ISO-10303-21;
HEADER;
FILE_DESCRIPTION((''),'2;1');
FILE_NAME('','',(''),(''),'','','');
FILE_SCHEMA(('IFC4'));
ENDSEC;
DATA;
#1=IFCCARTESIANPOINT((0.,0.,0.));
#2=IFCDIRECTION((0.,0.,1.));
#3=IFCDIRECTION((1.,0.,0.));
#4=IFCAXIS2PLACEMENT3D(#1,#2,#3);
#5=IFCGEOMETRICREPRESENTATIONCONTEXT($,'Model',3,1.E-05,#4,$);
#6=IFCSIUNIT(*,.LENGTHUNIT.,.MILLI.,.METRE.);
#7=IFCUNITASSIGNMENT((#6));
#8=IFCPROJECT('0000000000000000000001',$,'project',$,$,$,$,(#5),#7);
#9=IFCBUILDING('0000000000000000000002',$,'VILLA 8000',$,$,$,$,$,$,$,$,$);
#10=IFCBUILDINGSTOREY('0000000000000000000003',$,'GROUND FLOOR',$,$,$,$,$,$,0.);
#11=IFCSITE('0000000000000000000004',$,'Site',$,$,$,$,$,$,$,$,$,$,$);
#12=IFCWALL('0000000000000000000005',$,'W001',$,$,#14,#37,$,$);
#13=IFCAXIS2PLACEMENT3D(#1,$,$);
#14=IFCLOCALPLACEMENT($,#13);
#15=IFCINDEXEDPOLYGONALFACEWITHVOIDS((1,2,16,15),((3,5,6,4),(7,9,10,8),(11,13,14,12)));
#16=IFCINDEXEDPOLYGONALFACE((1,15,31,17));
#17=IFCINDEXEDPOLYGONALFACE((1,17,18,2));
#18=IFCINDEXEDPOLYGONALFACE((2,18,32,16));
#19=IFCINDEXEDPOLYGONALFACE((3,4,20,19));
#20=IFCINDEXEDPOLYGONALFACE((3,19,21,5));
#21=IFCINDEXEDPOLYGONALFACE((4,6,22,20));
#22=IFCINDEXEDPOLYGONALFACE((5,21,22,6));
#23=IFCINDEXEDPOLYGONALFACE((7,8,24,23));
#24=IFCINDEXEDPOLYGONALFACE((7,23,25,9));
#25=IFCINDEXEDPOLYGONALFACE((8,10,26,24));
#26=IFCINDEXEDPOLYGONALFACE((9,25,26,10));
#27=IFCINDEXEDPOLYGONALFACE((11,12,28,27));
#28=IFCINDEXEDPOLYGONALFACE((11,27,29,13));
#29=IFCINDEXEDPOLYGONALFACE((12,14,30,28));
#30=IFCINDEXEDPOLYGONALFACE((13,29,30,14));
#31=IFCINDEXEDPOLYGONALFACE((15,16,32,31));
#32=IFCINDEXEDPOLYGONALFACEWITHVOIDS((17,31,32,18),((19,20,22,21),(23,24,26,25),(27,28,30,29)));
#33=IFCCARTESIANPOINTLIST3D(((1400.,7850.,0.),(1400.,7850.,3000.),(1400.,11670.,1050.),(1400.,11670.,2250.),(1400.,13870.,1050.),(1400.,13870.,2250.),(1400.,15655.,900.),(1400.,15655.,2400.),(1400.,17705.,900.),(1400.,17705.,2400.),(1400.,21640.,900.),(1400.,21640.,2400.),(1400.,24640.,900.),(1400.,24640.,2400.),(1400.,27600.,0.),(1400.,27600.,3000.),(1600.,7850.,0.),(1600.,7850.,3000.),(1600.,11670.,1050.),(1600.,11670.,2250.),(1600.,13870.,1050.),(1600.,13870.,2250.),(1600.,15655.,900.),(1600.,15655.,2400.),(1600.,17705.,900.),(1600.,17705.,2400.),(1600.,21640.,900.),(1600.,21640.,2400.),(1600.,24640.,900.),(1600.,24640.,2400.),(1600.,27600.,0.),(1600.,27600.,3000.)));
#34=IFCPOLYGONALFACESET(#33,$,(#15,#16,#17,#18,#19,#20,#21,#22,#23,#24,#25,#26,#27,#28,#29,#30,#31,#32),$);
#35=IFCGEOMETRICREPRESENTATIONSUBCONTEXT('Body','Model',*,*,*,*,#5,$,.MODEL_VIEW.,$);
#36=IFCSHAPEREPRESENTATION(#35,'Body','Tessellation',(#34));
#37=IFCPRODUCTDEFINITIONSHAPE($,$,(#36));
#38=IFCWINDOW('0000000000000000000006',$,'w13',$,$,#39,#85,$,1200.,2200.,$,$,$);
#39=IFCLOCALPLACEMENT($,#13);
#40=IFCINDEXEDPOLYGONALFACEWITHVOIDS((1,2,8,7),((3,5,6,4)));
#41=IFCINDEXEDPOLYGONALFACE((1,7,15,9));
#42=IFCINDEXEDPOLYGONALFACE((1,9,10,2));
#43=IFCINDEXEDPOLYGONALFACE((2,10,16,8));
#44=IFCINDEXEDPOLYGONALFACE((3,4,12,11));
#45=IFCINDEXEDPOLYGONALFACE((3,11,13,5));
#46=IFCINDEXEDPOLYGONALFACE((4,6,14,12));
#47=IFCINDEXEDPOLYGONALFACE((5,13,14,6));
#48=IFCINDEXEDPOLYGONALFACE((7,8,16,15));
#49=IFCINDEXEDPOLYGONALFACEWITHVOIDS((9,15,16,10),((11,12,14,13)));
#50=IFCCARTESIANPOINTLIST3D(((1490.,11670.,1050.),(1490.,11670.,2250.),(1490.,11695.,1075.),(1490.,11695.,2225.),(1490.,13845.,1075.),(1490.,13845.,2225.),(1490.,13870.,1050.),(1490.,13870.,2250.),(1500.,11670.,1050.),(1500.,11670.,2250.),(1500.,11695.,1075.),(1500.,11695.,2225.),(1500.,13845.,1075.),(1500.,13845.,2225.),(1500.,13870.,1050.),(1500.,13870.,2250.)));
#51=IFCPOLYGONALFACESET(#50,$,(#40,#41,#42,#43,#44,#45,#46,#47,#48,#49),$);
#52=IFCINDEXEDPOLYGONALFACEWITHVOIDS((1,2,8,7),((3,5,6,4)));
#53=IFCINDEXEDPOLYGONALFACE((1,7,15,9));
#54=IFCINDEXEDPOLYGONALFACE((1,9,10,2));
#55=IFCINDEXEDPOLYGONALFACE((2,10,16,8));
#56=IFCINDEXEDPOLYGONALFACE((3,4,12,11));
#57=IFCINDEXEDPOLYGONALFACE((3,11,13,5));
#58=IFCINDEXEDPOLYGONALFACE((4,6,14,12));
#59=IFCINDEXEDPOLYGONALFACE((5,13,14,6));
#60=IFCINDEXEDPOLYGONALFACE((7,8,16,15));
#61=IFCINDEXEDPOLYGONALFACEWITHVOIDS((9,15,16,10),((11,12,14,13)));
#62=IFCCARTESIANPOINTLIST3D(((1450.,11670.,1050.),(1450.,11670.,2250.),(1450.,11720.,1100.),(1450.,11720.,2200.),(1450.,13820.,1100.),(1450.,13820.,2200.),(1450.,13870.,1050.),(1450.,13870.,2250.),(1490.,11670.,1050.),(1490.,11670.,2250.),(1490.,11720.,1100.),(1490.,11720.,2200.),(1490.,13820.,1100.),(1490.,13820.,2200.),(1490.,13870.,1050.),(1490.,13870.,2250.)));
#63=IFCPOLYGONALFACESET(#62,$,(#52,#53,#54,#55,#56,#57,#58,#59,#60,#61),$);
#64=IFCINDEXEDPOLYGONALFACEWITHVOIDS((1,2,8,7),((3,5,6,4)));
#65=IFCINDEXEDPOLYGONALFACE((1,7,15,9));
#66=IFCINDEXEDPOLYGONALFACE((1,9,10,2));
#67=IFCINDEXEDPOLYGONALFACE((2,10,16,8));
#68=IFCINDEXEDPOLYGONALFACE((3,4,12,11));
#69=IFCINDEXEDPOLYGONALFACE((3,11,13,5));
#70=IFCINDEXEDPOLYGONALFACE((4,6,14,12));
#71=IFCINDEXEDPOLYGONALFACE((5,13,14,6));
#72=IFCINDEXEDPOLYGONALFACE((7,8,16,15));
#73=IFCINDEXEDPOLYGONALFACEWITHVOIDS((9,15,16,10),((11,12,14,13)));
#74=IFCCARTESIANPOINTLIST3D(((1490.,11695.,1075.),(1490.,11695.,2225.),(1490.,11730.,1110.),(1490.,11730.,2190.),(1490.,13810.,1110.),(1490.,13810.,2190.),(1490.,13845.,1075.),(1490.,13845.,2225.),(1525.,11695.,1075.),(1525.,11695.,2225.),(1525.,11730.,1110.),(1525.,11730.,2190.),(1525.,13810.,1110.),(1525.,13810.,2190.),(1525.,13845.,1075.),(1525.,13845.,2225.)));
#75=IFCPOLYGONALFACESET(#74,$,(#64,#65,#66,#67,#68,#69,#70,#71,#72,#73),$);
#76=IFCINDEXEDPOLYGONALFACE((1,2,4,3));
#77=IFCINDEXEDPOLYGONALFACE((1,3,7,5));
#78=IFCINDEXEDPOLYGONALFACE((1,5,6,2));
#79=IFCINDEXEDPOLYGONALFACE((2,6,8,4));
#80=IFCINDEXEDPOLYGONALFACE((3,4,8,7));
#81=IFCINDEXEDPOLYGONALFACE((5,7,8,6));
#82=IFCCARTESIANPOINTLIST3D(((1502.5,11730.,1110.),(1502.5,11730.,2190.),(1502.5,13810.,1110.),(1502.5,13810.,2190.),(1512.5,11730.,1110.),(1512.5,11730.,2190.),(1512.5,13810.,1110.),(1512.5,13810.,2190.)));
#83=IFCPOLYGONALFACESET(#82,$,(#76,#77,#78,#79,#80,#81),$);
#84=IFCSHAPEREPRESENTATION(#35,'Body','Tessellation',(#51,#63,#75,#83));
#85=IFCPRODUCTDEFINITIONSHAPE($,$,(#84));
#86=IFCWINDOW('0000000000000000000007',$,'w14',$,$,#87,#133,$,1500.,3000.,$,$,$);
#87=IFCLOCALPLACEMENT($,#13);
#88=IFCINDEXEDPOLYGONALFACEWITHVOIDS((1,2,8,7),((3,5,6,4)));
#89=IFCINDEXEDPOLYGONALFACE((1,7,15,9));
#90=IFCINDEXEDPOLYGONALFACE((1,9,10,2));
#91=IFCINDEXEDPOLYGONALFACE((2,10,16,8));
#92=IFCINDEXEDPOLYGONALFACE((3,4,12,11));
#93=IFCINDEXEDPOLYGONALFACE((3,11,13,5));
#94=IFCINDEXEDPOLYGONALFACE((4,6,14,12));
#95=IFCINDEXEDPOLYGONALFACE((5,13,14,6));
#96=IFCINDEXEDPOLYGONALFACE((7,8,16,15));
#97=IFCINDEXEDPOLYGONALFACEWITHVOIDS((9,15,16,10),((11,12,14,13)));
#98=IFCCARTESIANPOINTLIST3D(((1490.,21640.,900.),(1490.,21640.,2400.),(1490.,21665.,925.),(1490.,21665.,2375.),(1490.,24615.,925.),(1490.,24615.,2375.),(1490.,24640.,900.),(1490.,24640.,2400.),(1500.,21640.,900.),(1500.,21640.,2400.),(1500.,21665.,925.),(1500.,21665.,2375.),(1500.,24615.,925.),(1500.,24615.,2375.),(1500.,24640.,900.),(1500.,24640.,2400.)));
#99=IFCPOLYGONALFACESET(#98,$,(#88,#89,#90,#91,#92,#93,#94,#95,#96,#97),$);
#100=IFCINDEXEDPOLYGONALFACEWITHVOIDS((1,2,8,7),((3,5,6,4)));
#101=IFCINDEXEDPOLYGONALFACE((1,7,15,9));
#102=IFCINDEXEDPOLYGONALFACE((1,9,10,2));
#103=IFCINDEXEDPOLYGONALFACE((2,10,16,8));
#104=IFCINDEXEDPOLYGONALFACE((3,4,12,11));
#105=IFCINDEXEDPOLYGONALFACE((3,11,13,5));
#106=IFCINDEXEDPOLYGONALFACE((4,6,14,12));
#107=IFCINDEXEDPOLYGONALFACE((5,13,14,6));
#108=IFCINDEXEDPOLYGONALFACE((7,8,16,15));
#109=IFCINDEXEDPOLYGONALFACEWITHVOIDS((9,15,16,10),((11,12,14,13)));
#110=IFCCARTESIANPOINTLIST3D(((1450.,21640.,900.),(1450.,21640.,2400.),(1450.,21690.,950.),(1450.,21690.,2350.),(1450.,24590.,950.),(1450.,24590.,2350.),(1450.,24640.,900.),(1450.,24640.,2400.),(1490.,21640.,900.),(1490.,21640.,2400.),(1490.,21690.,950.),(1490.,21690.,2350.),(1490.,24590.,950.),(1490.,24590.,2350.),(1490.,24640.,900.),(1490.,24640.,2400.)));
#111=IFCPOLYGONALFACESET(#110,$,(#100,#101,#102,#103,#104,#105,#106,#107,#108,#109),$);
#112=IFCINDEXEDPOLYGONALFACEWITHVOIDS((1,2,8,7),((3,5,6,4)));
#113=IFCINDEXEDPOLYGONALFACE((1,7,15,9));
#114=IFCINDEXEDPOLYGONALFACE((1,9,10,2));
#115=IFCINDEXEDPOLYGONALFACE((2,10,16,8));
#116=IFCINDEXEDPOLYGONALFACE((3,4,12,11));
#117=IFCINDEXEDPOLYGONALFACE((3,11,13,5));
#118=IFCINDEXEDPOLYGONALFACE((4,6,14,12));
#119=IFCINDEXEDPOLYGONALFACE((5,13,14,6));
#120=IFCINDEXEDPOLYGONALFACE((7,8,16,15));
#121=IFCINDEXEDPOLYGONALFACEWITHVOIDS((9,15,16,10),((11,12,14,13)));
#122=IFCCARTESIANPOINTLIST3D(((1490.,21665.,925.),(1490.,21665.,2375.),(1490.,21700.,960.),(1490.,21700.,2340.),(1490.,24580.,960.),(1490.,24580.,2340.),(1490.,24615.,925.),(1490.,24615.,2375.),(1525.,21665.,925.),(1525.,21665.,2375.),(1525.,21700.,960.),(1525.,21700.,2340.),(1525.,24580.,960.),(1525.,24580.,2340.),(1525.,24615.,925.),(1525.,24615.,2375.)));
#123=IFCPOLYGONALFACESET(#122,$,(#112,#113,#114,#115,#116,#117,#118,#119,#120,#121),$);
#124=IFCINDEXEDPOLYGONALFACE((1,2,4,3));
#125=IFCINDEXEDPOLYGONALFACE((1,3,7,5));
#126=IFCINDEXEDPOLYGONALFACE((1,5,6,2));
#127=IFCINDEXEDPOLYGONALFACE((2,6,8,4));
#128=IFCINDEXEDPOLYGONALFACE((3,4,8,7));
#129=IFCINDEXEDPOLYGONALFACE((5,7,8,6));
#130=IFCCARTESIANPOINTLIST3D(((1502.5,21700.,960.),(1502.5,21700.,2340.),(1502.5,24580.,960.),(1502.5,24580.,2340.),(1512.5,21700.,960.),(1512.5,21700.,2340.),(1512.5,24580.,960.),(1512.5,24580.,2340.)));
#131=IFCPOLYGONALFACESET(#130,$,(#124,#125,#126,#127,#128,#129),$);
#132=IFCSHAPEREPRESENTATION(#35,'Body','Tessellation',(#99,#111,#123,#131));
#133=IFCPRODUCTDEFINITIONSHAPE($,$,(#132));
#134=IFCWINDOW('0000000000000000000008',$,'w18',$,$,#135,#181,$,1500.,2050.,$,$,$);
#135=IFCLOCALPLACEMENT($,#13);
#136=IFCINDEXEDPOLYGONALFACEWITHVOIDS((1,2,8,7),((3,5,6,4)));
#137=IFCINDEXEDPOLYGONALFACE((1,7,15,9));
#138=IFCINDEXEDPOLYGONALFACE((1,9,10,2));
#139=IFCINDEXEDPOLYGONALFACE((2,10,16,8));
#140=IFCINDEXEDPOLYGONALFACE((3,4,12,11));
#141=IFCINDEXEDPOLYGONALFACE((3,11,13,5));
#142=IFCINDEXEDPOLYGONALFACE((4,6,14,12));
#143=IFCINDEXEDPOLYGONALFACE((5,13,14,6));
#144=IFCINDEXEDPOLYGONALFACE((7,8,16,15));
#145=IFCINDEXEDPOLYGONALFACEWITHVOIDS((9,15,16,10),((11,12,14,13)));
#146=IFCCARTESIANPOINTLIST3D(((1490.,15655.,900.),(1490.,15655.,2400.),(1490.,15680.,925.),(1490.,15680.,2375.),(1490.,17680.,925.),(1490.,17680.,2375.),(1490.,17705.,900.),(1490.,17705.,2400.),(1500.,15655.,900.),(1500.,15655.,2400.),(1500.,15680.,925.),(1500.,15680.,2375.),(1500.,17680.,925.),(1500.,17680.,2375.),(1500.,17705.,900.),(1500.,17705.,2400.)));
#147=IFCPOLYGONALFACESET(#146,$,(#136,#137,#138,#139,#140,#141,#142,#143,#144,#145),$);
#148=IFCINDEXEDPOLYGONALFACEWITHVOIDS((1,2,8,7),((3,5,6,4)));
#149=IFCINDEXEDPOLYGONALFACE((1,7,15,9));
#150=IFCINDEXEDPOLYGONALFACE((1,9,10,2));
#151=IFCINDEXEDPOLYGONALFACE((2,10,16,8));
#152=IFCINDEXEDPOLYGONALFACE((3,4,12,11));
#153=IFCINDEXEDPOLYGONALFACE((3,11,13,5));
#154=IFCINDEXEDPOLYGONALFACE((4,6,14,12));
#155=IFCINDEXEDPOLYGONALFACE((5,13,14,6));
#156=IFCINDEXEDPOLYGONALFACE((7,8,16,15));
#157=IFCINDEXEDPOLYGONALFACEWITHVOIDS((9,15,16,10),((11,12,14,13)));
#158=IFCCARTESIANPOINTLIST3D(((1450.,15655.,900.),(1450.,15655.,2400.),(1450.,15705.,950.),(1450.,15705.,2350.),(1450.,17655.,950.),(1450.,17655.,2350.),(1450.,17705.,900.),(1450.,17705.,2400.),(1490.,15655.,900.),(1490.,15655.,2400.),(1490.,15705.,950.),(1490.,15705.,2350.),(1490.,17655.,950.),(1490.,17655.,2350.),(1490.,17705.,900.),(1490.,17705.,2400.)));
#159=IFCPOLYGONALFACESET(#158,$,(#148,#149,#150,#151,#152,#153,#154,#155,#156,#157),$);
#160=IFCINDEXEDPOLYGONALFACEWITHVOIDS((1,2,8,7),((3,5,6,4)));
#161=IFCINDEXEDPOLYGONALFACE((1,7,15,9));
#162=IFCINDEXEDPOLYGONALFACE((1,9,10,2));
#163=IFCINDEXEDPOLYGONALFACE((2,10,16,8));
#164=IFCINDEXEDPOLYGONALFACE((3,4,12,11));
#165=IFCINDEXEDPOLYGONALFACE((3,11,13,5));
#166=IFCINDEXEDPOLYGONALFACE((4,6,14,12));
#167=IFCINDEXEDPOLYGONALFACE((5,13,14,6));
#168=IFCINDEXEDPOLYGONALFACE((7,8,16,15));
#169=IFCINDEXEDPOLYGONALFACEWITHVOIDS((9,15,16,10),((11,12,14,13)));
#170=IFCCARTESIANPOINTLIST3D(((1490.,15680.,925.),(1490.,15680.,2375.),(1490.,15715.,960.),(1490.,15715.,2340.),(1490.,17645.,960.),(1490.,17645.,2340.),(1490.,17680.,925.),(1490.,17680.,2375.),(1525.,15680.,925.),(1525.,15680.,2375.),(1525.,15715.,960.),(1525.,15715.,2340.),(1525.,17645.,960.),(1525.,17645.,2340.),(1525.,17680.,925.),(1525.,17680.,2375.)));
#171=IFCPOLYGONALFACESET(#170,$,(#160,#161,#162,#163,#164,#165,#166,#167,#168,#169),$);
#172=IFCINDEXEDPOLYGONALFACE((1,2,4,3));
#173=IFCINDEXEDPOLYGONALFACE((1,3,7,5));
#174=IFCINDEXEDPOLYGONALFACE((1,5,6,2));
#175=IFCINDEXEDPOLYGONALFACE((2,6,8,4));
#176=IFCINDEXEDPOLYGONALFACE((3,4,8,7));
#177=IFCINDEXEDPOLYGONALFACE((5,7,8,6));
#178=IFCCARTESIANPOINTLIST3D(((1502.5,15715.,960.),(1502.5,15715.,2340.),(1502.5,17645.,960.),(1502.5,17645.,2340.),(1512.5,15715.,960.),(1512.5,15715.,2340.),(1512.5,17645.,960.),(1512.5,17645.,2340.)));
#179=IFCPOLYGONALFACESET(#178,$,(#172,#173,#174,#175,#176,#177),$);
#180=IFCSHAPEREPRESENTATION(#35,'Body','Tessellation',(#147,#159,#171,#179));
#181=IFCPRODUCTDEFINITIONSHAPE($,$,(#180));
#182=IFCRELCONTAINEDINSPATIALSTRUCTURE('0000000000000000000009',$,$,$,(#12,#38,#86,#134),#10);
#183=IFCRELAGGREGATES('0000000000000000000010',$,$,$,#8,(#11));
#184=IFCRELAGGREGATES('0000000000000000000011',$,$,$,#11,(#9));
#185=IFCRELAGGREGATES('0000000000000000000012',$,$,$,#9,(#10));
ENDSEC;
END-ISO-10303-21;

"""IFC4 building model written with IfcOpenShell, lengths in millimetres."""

from ifc_helpers import new_model, si_unit, frame, origin_with_axes, place, context, subcontext, project, spatial, line, indexed_curve, outline, extrude, element, fill, save


model = new_model("IFC4")

# Units and contexts
model_context = context("Model", 3, precision=1e-05, world=origin_with_axes())
body_context = subcontext(model_context, "Body", "Model", "MODEL_VIEW")
ifc_project = project(units=[si_unit("LENGTHUNIT", "METRE", prefix="MILLI")], contexts=[model_context])

# Site, building, storey
site = spatial("IfcSite", under=ifc_project, Name="Site")
building = spatial("IfcBuilding", under=site, Name="VILLA 8000")
storey = spatial("IfcBuildingStorey", under=building, Name="GROUND FLOOR", Elevation=0.0)

# Wall, openings, windows
wall_1_placement = place(None, frame((1500.0, 27600.0, 0.0), z_axis=(0.0, 0.0, 1.0), x_axis=(0.0, -1.0, 0.0)))
wall_1 = element("IfcWall", 1, at=wall_1_placement, inside=storey, Name="W001", context=body_context, shape_type="SweptSolid", body=[
    extrude(outline(indexed_curve([(0.0, 0.0), (0.0, 200.0), (19750.0, 200.0), (19750.0, 0.0), (0.0, 0.0)], self_intersect=False)), frame((0.0, -100.0, 0.0), z_axis=(0.0, 0.0, 1.0), x_axis=(1.0, 0.0, 0.0)), (0.0, 0.0, 1.0), 3000.0),
])
opening_1_placement = place(wall_1_placement, frame((13730.0, 0.0, 1050.0), z_axis=(0.0, 0.0, 1.0), x_axis=(1.0, 0.0, 0.0)))
opening_1 = element("IfcOpeningElement", 2, at=opening_1_placement, cuts=wall_1, context=body_context, shape_type="SweptSolid", body=[
    extrude(outline(indexed_curve([(0.0, 0.0), (0.0, 300.0), (2200.0, 300.0), (2200.0, 0.0), (0.0, 0.0)], self_intersect=False)), frame((0.0, -150.0, 0.0), z_axis=(0.0, 0.0, 1.0), x_axis=(1.0, 0.0, 0.0)), (0.0, 0.0, 1.0), 1200.0),
])
opening_2_placement = place(wall_1_placement, frame((2960.0, 0.0, 900.0), z_axis=(0.0, 0.0, 1.0), x_axis=(1.0, 0.0, 0.0)))
opening_2 = element("IfcOpeningElement", 3, at=opening_2_placement, cuts=wall_1, context=body_context, shape_type="SweptSolid", body=[
    extrude(outline(indexed_curve([(0.0, 0.0), (0.0, 300.0), (3000.0, 300.0), (3000.0, 0.0), (0.0, 0.0)], self_intersect=False)), frame((0.0, -150.0, 0.0), z_axis=(0.0, 0.0, 1.0), x_axis=(1.0, 0.0, 0.0)), (0.0, 0.0, 1.0), 1500.0),
])
opening_3_placement = place(wall_1_placement, frame((9895.0, 0.0, 900.0), z_axis=(0.0, 0.0, 1.0), x_axis=(1.0, 0.0, 0.0)))
opening_3 = element("IfcOpeningElement", 4, at=opening_3_placement, cuts=wall_1, context=body_context, shape_type="SweptSolid", body=[
    extrude(outline(indexed_curve([(0.0, 0.0), (0.0, 300.0), (2050.0, 300.0), (2050.0, 0.0), (0.0, 0.0)], self_intersect=False)), frame((0.0, -150.0, 0.0), z_axis=(0.0, 0.0, 1.0), x_axis=(1.0, 0.0, 0.0)), (0.0, 0.0, 1.0), 1500.0),
])
window_1_placement = place(None, frame((1400.0, 13870.0, 1050.0), z_axis=(0.0, 0.0, 1.0), x_axis=(0.0, -1.0, 0.0)))
window_1 = element("IfcWindow", 5, at=window_1_placement, inside=storey, Name="w13", OverallHeight=1200.0, OverallWidth=2200.0, context=body_context, shape_type="SweptSolid", body=[
    extrude(outline(indexed_curve([(0.0, 0.0), (2200.0, 0.0), (2200.0, 1200.0), (0.0, 1200.0)], segments=[line(1, 2, 3, 4, 1)]), holes=[indexed_curve([(25.0, 25.0), (2175.0, 25.0), (2175.0, 1175.0), (25.0, 1175.0)], segments=[line(1, 2, 3, 4, 1)])]), frame((0.0, 90.0, 0.0), z_axis=(0.0, -1.0, 0.0), x_axis=(1.0, 0.0, 0.0)), (0.0, 0.0, -1.0), 10.0),
    extrude(outline(indexed_curve([(0.0, 0.0), (2200.0, 0.0), (2200.0, 1200.0), (0.0, 1200.0)], segments=[line(1, 2, 3, 4, 1)]), holes=[indexed_curve([(50.0, 50.0), (2150.0, 50.0), (2150.0, 1150.0), (50.0, 1150.0)], segments=[line(1, 2, 3, 4, 1)])]), frame((0.0, 50.0, 0.0), z_axis=(0.0, -1.0, 0.0), x_axis=(1.0, 0.0, 0.0)), (0.0, 0.0, -1.0), 40.0),
    extrude(outline(indexed_curve([(0.0, 0.0), (2150.0, 0.0), (2150.0, 1150.0), (0.0, 1150.0)], segments=[line(1, 2, 3, 4, 1)]), holes=[indexed_curve([(35.0, 35.0), (2115.0, 35.0), (2115.0, 1115.0), (35.0, 1115.0)], segments=[line(1, 2, 3, 4, 1)])]), frame((25.0, 90.0, 25.0), z_axis=(0.0, -1.0, 0.0), x_axis=(1.0, 0.0, 0.0)), (0.0, 0.0, -1.0), 35.0),
    extrude(outline(indexed_curve([(35.0, 35.0), (2115.0, 35.0), (2115.0, 1115.0), (35.0, 1115.0)], segments=[line(1, 2, 3, 4, 1)])), frame((25.0, 102.5, 25.0), z_axis=(0.0, -1.0, 0.0), x_axis=(1.0, 0.0, 0.0)), (0.0, 0.0, -1.0), 10.0),
])
fill(opening_1, window_1)
window_2_placement = place(None, frame((1400.0, 24640.0, 900.0), z_axis=(0.0, 0.0, 1.0), x_axis=(0.0, -1.0, 0.0)))
window_2 = element("IfcWindow", 6, at=window_2_placement, inside=storey, Name="w14", OverallHeight=1500.0, OverallWidth=3000.0, context=body_context, shape_type="SweptSolid", body=[
    extrude(outline(indexed_curve([(0.0, 0.0), (3000.0, 0.0), (3000.0, 1500.0), (0.0, 1500.0)], segments=[line(1, 2, 3, 4, 1)]), holes=[indexed_curve([(25.0, 25.0), (2975.0, 25.0), (2975.0, 1475.0), (25.0, 1475.0)], segments=[line(1, 2, 3, 4, 1)])]), frame((0.0, 90.0, 0.0), z_axis=(0.0, -1.0, 0.0), x_axis=(1.0, 0.0, 0.0)), (0.0, 0.0, -1.0), 10.0),
    extrude(outline(indexed_curve([(0.0, 0.0), (3000.0, 0.0), (3000.0, 1500.0), (0.0, 1500.0)], segments=[line(1, 2, 3, 4, 1)]), holes=[indexed_curve([(50.0, 50.0), (2950.0, 50.0), (2950.0, 1450.0), (50.0, 1450.0)], segments=[line(1, 2, 3, 4, 1)])]), frame((0.0, 50.0, 0.0), z_axis=(0.0, -1.0, 0.0), x_axis=(1.0, 0.0, 0.0)), (0.0, 0.0, -1.0), 40.0),
    extrude(outline(indexed_curve([(0.0, 0.0), (2950.0, 0.0), (2950.0, 1450.0), (0.0, 1450.0)], segments=[line(1, 2, 3, 4, 1)]), holes=[indexed_curve([(35.0, 35.0), (2915.0, 35.0), (2915.0, 1415.0), (35.0, 1415.0)], segments=[line(1, 2, 3, 4, 1)])]), frame((25.0, 90.0, 25.0), z_axis=(0.0, -1.0, 0.0), x_axis=(1.0, 0.0, 0.0)), (0.0, 0.0, -1.0), 35.0),
    extrude(outline(indexed_curve([(35.0, 35.0), (2915.0, 35.0), (2915.0, 1415.0), (35.0, 1415.0)], segments=[line(1, 2, 3, 4, 1)])), frame((25.0, 102.5, 25.0), z_axis=(0.0, -1.0, 0.0), x_axis=(1.0, 0.0, 0.0)), (0.0, 0.0, -1.0), 10.0),
])
fill(opening_2, window_2)
window_3_placement = place(None, frame((1400.0, 17705.0, 900.0), z_axis=(0.0, 0.0, 1.0), x_axis=(0.0, -1.0, 0.0)))
window_3 = element("IfcWindow", 7, at=window_3_placement, inside=storey, Name="w18", OverallHeight=1500.0, OverallWidth=2050.0, context=body_context, shape_type="SweptSolid", body=[
    extrude(outline(indexed_curve([(0.0, 0.0), (2050.0, 0.0), (2050.0, 1500.0), (0.0, 1500.0)], segments=[line(1, 2, 3, 4, 1)]), holes=[indexed_curve([(25.0, 25.0), (2025.0, 25.0), (2025.0, 1475.0), (25.0, 1475.0)], segments=[line(1, 2, 3, 4, 1)])]), frame((0.0, 90.0, 0.0), z_axis=(0.0, -1.0, 0.0), x_axis=(1.0, 0.0, 0.0)), (0.0, 0.0, -1.0), 10.0),
    extrude(outline(indexed_curve([(0.0, 0.0), (2050.0, 0.0), (2050.0, 1500.0), (0.0, 1500.0)], segments=[line(1, 2, 3, 4, 1)]), holes=[indexed_curve([(50.0, 50.0), (2000.0, 50.0), (2000.0, 1450.0), (50.0, 1450.0)], segments=[line(1, 2, 3, 4, 1)])]), frame((0.0, 50.0, 0.0), z_axis=(0.0, -1.0, 0.0), x_axis=(1.0, 0.0, 0.0)), (0.0, 0.0, -1.0), 40.0),
    extrude(outline(indexed_curve([(0.0, 0.0), (2000.0, 0.0), (2000.0, 1450.0), (0.0, 1450.0)], segments=[line(1, 2, 3, 4, 1)]), holes=[indexed_curve([(35.0, 35.0), (1965.0, 35.0), (1965.0, 1415.0), (35.0, 1415.0)], segments=[line(1, 2, 3, 4, 1)])]), frame((25.0, 90.0, 25.0), z_axis=(0.0, -1.0, 0.0), x_axis=(1.0, 0.0, 0.0)), (0.0, 0.0, -1.0), 35.0),
    extrude(outline(indexed_curve([(35.0, 35.0), (1965.0, 35.0), (1965.0, 1415.0), (35.0, 1415.0)], segments=[line(1, 2, 3, 4, 1)])), frame((25.0, 102.5, 25.0), z_axis=(0.0, -1.0, 0.0), x_axis=(1.0, 0.0, 0.0)), (0.0, 0.0, -1.0), 10.0),
])
fill(opening_3, window_3)

save(model, "model.ifc")
